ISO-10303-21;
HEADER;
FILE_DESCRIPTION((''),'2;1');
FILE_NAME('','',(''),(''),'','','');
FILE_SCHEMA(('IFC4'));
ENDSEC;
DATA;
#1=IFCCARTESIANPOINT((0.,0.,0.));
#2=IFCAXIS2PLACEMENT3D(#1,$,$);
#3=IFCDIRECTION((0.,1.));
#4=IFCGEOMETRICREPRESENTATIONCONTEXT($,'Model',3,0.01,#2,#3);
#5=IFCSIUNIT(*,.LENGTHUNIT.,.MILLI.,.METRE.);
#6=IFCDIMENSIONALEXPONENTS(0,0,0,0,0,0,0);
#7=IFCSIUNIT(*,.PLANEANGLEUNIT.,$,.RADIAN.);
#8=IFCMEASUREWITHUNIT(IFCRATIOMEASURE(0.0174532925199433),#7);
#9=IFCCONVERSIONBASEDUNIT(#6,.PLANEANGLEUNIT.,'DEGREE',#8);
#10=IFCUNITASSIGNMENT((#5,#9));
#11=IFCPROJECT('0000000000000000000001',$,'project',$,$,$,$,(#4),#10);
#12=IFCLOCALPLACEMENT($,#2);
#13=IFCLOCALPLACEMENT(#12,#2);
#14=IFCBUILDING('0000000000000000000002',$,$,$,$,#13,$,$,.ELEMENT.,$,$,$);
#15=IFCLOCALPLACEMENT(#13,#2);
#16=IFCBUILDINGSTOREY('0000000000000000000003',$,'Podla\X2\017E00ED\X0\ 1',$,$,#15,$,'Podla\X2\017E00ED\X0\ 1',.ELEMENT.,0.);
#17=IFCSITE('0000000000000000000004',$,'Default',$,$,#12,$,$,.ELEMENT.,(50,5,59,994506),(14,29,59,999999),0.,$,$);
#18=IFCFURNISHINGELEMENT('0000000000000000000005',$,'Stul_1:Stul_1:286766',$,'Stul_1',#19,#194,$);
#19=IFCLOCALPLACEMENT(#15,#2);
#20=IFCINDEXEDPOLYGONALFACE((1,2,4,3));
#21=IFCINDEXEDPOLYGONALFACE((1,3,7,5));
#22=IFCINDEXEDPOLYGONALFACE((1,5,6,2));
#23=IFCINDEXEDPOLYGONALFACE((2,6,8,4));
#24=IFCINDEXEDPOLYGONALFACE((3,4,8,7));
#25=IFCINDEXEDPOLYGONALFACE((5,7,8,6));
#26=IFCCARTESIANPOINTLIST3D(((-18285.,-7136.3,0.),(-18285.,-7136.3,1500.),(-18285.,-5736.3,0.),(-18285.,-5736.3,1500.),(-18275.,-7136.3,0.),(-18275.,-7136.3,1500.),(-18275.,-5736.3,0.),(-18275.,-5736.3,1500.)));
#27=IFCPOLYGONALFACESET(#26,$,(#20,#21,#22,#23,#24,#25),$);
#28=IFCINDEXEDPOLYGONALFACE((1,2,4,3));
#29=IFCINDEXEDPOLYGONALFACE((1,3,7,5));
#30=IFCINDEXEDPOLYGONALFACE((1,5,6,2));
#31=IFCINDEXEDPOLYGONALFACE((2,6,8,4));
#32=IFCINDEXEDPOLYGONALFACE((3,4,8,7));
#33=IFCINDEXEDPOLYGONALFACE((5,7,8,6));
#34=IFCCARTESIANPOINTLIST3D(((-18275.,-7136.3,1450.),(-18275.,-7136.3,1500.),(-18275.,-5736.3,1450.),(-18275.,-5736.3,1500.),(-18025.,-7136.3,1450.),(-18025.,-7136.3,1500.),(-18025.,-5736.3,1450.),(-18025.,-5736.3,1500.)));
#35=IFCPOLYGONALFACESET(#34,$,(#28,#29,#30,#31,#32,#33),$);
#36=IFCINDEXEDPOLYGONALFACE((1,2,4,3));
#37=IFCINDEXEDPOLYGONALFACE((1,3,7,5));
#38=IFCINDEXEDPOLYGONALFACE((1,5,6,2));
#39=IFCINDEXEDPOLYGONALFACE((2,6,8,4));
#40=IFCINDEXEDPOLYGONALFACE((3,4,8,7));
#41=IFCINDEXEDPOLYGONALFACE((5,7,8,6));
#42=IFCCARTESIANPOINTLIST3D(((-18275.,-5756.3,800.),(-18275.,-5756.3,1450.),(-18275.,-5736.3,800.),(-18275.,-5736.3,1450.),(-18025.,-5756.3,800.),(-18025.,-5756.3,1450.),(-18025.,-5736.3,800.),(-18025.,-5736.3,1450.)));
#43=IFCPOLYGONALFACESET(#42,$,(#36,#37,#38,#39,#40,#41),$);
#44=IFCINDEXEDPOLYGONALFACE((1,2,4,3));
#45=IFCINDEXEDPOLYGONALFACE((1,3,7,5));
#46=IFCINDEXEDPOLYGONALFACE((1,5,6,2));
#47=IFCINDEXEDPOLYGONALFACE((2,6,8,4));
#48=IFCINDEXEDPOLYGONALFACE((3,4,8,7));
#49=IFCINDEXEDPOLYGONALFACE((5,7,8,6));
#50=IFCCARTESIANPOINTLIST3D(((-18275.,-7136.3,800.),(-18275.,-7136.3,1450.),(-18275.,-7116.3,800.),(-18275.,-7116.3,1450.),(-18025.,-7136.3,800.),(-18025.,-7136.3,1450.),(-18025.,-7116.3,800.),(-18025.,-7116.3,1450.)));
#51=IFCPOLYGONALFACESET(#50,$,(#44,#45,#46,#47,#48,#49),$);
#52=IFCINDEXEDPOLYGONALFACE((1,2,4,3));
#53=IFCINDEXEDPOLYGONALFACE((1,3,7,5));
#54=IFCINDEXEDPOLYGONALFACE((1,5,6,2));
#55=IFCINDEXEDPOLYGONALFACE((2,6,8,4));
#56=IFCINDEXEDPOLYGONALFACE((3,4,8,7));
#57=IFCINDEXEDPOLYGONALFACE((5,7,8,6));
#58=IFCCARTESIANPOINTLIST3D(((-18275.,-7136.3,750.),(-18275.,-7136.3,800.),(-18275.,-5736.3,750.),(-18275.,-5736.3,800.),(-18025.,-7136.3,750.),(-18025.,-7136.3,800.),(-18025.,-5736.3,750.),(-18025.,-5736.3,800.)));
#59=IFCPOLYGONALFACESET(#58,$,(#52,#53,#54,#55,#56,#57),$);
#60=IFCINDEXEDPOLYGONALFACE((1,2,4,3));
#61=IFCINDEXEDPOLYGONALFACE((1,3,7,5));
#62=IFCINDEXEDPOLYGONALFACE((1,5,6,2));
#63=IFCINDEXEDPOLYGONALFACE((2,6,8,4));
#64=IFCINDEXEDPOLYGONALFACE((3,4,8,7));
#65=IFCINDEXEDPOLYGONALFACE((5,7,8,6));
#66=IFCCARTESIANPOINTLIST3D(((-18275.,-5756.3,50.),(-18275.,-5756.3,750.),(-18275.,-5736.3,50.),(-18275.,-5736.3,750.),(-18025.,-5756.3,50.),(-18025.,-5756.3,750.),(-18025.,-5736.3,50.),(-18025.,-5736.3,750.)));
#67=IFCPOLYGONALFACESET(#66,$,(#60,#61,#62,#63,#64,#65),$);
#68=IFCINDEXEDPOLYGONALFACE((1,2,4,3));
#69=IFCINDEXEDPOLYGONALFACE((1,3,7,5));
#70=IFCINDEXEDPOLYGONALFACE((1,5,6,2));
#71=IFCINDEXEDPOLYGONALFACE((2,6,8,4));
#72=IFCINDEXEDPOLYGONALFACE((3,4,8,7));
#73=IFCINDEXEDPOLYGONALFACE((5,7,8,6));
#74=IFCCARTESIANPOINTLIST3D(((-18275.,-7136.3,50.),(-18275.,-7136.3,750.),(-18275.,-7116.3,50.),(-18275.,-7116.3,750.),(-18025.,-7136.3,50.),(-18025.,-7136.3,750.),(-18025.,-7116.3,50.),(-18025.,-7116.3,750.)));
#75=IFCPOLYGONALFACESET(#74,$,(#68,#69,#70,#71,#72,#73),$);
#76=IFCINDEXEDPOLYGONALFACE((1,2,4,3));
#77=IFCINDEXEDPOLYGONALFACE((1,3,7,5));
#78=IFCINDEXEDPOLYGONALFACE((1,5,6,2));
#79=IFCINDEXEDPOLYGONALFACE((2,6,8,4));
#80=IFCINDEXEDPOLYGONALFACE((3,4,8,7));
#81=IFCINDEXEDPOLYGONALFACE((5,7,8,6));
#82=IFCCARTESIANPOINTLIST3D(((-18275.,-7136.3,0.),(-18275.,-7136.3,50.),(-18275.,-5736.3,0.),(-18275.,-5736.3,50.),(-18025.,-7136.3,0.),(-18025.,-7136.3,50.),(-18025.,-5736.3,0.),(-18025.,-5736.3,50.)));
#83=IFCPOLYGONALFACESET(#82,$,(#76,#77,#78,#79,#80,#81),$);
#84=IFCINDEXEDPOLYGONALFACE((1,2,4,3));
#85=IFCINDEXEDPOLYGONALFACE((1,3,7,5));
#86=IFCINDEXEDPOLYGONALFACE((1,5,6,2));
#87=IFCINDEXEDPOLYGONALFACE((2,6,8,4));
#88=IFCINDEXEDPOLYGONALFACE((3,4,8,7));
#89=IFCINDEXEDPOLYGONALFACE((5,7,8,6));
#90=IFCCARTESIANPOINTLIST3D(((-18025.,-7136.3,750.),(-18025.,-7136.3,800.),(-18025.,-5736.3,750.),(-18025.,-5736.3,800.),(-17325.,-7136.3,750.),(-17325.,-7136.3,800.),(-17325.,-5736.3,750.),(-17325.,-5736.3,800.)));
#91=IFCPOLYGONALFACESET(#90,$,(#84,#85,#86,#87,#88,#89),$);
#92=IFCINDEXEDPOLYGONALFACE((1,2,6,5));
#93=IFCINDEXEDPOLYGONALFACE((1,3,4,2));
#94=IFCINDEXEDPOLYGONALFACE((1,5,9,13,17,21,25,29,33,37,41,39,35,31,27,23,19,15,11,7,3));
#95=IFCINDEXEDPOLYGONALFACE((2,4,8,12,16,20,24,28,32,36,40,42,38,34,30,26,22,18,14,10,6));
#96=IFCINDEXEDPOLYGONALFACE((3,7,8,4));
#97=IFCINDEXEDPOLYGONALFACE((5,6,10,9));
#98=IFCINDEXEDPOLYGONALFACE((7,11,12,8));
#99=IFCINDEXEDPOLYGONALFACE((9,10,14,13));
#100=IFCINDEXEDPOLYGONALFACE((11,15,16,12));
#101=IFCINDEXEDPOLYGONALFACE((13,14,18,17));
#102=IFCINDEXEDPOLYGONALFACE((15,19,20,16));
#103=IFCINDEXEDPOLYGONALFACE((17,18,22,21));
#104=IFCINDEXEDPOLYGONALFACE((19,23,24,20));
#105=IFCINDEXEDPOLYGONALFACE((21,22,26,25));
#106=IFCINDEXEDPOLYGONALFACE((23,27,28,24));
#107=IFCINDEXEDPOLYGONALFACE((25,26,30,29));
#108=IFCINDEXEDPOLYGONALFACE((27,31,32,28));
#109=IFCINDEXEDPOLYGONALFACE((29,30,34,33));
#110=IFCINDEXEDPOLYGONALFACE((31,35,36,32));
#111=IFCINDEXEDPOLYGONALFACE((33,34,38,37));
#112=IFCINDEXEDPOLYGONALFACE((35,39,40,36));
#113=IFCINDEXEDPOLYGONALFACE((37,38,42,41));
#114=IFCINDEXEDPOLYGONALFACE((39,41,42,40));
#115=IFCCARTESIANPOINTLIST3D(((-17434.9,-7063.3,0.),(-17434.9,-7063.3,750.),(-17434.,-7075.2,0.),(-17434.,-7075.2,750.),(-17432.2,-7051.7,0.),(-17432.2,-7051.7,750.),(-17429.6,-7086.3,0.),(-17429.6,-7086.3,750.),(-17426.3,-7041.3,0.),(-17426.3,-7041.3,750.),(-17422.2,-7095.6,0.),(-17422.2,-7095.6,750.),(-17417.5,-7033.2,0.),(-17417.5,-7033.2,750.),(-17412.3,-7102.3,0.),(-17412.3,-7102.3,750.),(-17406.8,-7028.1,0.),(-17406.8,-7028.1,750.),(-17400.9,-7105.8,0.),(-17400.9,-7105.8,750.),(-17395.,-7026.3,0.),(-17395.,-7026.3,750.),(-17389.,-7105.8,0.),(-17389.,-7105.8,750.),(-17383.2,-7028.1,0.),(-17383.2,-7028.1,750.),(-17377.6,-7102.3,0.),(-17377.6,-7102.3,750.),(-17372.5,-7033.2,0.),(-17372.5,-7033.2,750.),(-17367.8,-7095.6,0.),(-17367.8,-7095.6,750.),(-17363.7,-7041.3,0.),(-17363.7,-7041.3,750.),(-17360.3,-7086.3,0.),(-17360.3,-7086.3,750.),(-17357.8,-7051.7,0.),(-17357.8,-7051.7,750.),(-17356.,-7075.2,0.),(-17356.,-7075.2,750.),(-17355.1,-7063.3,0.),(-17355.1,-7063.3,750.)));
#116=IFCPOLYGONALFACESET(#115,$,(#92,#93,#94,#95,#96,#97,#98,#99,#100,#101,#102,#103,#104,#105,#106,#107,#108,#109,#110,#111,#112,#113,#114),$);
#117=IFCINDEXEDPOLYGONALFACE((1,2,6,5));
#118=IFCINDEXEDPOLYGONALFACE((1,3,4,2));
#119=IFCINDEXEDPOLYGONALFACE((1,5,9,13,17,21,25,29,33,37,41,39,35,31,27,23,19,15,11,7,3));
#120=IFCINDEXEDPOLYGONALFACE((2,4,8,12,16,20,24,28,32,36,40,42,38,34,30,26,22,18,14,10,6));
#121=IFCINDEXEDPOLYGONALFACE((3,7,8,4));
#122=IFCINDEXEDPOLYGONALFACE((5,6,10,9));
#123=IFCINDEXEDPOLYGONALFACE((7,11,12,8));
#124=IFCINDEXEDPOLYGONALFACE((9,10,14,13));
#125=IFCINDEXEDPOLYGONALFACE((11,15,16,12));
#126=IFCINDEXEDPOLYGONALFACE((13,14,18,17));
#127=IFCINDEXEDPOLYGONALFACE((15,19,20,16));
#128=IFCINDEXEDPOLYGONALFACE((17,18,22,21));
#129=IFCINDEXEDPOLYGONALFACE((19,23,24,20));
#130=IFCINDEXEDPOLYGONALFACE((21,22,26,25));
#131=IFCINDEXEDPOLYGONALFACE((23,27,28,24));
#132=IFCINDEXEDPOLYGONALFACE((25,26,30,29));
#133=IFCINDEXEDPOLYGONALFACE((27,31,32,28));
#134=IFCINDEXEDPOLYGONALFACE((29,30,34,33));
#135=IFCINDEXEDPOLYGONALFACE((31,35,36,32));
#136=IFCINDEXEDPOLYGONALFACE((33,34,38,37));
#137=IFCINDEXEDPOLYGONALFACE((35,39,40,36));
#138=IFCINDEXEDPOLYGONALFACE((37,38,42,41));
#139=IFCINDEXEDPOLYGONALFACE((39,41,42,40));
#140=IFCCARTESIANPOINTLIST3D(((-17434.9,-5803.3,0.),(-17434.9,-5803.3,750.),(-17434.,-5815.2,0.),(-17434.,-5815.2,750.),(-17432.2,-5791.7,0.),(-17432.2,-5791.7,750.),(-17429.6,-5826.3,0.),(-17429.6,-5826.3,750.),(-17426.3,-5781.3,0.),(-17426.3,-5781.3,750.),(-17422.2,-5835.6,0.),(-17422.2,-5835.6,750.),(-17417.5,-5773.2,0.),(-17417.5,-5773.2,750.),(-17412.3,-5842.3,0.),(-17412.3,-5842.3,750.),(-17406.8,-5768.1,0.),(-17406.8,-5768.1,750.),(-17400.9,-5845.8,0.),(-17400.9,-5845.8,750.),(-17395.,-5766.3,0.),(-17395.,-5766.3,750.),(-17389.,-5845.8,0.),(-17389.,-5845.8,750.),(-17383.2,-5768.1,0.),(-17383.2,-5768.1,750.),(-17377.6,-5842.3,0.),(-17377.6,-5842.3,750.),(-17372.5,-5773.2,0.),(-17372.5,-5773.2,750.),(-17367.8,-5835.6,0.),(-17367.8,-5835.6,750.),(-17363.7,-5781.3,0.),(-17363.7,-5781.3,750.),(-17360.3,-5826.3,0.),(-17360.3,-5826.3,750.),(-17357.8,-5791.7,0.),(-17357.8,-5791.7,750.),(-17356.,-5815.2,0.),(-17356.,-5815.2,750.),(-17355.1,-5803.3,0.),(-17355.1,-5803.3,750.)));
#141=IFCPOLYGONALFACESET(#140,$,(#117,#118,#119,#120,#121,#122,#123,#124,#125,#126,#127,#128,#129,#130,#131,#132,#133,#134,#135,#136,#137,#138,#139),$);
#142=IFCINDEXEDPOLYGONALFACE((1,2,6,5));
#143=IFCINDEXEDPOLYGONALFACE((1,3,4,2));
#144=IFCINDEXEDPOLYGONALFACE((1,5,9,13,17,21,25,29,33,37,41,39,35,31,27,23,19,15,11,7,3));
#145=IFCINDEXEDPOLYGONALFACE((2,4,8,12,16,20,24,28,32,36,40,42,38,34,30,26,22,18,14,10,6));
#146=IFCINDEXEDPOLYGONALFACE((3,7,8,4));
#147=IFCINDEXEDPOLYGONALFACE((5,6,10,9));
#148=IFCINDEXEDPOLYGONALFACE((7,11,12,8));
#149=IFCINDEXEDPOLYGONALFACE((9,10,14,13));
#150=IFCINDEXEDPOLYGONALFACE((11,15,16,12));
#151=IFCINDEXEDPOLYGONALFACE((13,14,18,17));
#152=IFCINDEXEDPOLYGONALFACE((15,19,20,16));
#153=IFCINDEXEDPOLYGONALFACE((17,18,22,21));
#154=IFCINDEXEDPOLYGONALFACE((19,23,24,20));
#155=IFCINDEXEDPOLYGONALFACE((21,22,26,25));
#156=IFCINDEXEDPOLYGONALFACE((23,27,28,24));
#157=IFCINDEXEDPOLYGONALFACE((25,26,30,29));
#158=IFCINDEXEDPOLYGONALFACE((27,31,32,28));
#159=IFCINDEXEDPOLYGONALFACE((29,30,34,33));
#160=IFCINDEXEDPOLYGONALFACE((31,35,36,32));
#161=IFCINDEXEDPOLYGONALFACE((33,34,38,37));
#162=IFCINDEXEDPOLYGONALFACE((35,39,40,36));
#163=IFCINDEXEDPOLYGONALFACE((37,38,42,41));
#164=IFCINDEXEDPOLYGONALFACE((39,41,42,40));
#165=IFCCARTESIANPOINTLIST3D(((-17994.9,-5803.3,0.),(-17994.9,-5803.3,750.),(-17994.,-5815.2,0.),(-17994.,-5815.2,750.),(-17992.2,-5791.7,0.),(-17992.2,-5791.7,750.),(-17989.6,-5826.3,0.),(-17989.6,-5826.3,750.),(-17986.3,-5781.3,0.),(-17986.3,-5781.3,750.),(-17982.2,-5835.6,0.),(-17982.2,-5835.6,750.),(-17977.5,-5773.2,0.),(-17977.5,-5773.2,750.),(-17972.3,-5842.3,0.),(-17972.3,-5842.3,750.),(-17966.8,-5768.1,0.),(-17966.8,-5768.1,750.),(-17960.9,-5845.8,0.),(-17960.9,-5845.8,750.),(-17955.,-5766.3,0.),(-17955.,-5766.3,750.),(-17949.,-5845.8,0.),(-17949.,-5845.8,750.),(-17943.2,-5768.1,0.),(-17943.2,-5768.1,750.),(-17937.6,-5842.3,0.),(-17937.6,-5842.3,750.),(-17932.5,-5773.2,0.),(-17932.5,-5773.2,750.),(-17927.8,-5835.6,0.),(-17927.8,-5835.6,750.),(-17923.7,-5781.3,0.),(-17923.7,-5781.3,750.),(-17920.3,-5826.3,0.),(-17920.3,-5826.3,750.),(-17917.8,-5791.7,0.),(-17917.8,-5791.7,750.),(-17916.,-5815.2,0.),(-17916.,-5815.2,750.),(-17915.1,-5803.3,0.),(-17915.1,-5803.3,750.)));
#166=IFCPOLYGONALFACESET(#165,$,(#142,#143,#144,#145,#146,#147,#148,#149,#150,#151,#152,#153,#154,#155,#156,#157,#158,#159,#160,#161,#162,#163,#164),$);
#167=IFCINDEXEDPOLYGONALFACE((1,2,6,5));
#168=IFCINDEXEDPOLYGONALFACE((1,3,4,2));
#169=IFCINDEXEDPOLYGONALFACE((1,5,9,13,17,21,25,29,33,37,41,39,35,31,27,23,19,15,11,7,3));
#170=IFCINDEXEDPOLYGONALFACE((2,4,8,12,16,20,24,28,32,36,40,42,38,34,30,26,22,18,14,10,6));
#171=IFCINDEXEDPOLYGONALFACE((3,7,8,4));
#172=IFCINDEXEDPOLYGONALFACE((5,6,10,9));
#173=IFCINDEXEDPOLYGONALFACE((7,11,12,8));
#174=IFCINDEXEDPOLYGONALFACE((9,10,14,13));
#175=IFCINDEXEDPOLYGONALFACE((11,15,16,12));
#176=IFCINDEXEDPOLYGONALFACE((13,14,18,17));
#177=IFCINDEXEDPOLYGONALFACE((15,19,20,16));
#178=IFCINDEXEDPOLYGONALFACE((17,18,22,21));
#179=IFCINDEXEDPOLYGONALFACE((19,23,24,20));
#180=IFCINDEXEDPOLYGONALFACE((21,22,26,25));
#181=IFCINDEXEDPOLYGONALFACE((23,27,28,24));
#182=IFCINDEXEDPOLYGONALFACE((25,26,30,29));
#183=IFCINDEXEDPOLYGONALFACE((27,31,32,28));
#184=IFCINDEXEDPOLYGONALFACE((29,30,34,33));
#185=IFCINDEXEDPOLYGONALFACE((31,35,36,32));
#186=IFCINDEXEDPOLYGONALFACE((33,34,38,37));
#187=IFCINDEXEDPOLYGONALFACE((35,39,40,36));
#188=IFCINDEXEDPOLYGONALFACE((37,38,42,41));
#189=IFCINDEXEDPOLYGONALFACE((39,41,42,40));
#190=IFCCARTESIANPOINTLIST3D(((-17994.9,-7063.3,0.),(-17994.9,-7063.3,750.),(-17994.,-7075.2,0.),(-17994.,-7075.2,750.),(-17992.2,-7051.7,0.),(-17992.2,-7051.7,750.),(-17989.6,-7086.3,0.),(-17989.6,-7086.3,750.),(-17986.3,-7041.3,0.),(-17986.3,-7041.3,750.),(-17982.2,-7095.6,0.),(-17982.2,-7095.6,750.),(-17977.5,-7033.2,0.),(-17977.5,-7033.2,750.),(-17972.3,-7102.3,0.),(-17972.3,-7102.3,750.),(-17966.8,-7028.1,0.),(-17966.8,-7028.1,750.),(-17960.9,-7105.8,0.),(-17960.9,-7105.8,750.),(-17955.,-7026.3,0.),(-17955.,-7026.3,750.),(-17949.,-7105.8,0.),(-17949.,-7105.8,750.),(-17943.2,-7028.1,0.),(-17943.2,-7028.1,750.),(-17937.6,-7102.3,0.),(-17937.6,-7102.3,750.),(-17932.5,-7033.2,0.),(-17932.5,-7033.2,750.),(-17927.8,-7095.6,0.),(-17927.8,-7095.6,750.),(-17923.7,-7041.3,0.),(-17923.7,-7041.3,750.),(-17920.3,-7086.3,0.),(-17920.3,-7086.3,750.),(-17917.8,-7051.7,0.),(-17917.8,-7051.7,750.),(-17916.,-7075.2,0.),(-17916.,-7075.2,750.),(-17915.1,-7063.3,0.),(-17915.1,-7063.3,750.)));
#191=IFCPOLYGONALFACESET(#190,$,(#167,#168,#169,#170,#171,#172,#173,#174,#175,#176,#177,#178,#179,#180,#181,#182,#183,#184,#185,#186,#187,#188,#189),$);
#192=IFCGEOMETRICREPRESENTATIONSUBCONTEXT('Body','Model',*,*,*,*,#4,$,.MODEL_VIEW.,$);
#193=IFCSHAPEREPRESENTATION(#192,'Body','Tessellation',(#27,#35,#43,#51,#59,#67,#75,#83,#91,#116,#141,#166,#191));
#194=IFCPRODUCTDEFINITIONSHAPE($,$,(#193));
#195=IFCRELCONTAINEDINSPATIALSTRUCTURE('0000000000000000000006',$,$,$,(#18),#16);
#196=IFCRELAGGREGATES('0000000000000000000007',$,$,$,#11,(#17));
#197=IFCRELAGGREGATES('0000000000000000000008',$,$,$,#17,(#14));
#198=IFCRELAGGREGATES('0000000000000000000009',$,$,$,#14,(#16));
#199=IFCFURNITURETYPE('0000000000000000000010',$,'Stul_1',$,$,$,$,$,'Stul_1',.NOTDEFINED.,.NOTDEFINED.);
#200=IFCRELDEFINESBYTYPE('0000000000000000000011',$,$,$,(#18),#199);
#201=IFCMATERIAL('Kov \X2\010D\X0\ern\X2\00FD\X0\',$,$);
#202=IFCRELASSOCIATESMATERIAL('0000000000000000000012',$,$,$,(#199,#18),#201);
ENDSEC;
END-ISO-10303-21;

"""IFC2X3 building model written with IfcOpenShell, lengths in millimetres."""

from ifc_helpers import new_model, entity, si_unit, converted_unit, direction, frame, frame_2d, origin, origin_2d_with_axis, place, context, subcontext, project, spatial, rectangle, circle, extrude, source, transform, mapped, material, type_object, type_shapes, element, save


model = new_model("IFC2X3")

# Units and contexts
model_context = context("Model", 3, precision=0.01, world=origin(), true_north=direction((0.0, 1.0)))
body_context = subcontext(model_context, "Body", "Model", "MODEL_VIEW")
ifc_project = project(units=[si_unit("LENGTHUNIT", "METRE", prefix="MILLI"), converted_unit("PLANEANGLEUNIT", "DEGREE", entity("IfcRatioMeasure", 0.0174532925199433), si_unit("PLANEANGLEUNIT", "RADIAN"), dimensions=[0, 0, 0, 0, 0, 0, 0])], contexts=[model_context])

# Site, building, storey
site_placement = place(None, origin())
site = spatial("IfcSite", under=ifc_project, at=site_placement, Name="Default", CompositionType="ELEMENT", RefLatitude=(50, 5, 59, 994506), RefLongitude=(14, 29, 59, 999999), RefElevation=0.0)
building_placement = place(site_placement, origin())
building = spatial("IfcBuilding", under=site, at=building_placement, CompositionType="ELEMENT")
storey_placement = place(building_placement, origin())
storey = spatial("IfcBuildingStorey", under=building, at=storey_placement, Name="Podlaží 1", LongName="Podlaží 1", CompositionType="ELEMENT", Elevation=0.0)

# Furnishing element
ifc_material_1 = material(Name="Kov černý")
furniture_type = type_object("IfcFurnitureType", Name="Stul_1", ElementType="Stul_1", material=ifc_material_1)
shared_shape_1 = source(origin(), body_context, "Body", "SweptSolid", [
    extrude(rectangle(XDim=1400.0, YDim=10.0, at=origin_2d_with_axis()), frame((0.0, 605.0, 0.0), z_axis=(0.0, 0.0, 1.0), x_axis=(-1.0, 0.0, 0.0)), (0.0, 0.0, 1.0), 1500.0),
    extrude(rectangle(XDim=1400.0, YDim=250.0, at=frame_2d((0.0, 0.0), x_axis=(1.0, 0.0))), frame((0.0, 475.0, 1450.0), z_axis=(0.0, 0.0, 1.0), x_axis=(-1.0, 0.0, 0.0)), (0.0, 0.0, 1.0), 50.0),
    extrude(rectangle(XDim=20.0, YDim=250.0, at=origin_2d_with_axis()), frame((690.0, 475.0, 800.0), z_axis=(0.0, 0.0, 1.0), x_axis=(-1.0, 0.0, 0.0)), (0.0, 0.0, 1.0), 650.0),
    extrude(rectangle(XDim=20.0, YDim=250.0, at=frame_2d((0.0, 0.0), x_axis=(1.0, 0.0))), frame((-690.0, 475.0, 800.0), z_axis=(0.0, 0.0, 1.0), x_axis=(-1.0, 0.0, 0.0)), (0.0, 0.0, 1.0), 650.0),
    extrude(rectangle(XDim=1400.0, YDim=250.0, at=origin_2d_with_axis()), frame((0.0, 475.0, 750.0), z_axis=(0.0, 0.0, 1.0), x_axis=(-1.0, 0.0, 0.0)), (0.0, 0.0, 1.0), 50.0),
    extrude(rectangle(XDim=20.0, YDim=250.0, at=origin_2d_with_axis()), frame((690.0, 475.0, 50.0), z_axis=(0.0, 0.0, 1.0), x_axis=(-1.0, 0.0, 0.0)), (0.0, 0.0, 1.0), 700.0),
    extrude(rectangle(XDim=20.0, YDim=250.0, at=frame_2d((0.0, 0.0), x_axis=(1.0, 0.0))), frame((-690.0, 475.0, 50.0), z_axis=(0.0, 0.0, 1.0), x_axis=(-1.0, 0.0, 0.0)), (0.0, 0.0, 1.0), 700.0),
    extrude(rectangle(XDim=1400.0, YDim=250.0, at=origin_2d_with_axis()), frame((0.0, 475.0, 0.0), z_axis=(0.0, 0.0, 1.0), x_axis=(-1.0, 0.0, 0.0)), (0.0, 0.0, 1.0), 50.0),
    extrude(rectangle(XDim=1400.0, YDim=700.0, at=origin_2d_with_axis()), frame((0.0, 0.0, 750.0), z_axis=(0.0, 0.0, 1.0), x_axis=(-1.0, 0.0, 0.0)), (0.0, 0.0, 1.0), 50.0),
    extrude(circle(Radius=40.0, at=frame_2d((0.0, 0.0), x_axis=(1.0, 0.0))), frame((-630.0, -280.0, 0.0)), (0.0, 0.0, 1.0), 750.0),
    extrude(circle(Radius=40.0, at=frame_2d((0.0, 0.0), x_axis=(1.0, 0.0))), frame((630.0, -280.0, 0.0)), (0.0, 0.0, 1.0), 750.0),
    extrude(circle(Radius=40.0, at=frame_2d((0.0, 0.0), x_axis=(1.0, 0.0))), frame((630.0, 280.0, 0.0)), (0.0, 0.0, 1.0), 750.0),
    extrude(circle(Radius=40.0, at=frame_2d((0.0, 0.0), x_axis=(1.0, 0.0))), frame((-630.0, 280.0, 0.0)), (0.0, 0.0, 1.0), 750.0),
])
type_shapes(furniture_type, [shared_shape_1])
for number, where, z_axis, x_axis, name in (
    (1, (-17675.0, -6436.3, 0.0), (0.0, 0.0, 1.0), (0.0, 1.0, 0.0), "Stul_1:Stul_1:286766"),
):
    element("IfcFurnishingElement", number, at=place(storey_placement, frame(where, z_axis=z_axis, x_axis=x_axis)), inside=storey, type_object=furniture_type, material=ifc_material_1, Name=name, ObjectType="Stul_1", context=body_context, shape_type="MappedRepresentation", body=[
        mapped(shared_shape_1, transform((0.0, 0.0, 0.0), scale=1.0)),
    ])

save(model, "model.ifc")
